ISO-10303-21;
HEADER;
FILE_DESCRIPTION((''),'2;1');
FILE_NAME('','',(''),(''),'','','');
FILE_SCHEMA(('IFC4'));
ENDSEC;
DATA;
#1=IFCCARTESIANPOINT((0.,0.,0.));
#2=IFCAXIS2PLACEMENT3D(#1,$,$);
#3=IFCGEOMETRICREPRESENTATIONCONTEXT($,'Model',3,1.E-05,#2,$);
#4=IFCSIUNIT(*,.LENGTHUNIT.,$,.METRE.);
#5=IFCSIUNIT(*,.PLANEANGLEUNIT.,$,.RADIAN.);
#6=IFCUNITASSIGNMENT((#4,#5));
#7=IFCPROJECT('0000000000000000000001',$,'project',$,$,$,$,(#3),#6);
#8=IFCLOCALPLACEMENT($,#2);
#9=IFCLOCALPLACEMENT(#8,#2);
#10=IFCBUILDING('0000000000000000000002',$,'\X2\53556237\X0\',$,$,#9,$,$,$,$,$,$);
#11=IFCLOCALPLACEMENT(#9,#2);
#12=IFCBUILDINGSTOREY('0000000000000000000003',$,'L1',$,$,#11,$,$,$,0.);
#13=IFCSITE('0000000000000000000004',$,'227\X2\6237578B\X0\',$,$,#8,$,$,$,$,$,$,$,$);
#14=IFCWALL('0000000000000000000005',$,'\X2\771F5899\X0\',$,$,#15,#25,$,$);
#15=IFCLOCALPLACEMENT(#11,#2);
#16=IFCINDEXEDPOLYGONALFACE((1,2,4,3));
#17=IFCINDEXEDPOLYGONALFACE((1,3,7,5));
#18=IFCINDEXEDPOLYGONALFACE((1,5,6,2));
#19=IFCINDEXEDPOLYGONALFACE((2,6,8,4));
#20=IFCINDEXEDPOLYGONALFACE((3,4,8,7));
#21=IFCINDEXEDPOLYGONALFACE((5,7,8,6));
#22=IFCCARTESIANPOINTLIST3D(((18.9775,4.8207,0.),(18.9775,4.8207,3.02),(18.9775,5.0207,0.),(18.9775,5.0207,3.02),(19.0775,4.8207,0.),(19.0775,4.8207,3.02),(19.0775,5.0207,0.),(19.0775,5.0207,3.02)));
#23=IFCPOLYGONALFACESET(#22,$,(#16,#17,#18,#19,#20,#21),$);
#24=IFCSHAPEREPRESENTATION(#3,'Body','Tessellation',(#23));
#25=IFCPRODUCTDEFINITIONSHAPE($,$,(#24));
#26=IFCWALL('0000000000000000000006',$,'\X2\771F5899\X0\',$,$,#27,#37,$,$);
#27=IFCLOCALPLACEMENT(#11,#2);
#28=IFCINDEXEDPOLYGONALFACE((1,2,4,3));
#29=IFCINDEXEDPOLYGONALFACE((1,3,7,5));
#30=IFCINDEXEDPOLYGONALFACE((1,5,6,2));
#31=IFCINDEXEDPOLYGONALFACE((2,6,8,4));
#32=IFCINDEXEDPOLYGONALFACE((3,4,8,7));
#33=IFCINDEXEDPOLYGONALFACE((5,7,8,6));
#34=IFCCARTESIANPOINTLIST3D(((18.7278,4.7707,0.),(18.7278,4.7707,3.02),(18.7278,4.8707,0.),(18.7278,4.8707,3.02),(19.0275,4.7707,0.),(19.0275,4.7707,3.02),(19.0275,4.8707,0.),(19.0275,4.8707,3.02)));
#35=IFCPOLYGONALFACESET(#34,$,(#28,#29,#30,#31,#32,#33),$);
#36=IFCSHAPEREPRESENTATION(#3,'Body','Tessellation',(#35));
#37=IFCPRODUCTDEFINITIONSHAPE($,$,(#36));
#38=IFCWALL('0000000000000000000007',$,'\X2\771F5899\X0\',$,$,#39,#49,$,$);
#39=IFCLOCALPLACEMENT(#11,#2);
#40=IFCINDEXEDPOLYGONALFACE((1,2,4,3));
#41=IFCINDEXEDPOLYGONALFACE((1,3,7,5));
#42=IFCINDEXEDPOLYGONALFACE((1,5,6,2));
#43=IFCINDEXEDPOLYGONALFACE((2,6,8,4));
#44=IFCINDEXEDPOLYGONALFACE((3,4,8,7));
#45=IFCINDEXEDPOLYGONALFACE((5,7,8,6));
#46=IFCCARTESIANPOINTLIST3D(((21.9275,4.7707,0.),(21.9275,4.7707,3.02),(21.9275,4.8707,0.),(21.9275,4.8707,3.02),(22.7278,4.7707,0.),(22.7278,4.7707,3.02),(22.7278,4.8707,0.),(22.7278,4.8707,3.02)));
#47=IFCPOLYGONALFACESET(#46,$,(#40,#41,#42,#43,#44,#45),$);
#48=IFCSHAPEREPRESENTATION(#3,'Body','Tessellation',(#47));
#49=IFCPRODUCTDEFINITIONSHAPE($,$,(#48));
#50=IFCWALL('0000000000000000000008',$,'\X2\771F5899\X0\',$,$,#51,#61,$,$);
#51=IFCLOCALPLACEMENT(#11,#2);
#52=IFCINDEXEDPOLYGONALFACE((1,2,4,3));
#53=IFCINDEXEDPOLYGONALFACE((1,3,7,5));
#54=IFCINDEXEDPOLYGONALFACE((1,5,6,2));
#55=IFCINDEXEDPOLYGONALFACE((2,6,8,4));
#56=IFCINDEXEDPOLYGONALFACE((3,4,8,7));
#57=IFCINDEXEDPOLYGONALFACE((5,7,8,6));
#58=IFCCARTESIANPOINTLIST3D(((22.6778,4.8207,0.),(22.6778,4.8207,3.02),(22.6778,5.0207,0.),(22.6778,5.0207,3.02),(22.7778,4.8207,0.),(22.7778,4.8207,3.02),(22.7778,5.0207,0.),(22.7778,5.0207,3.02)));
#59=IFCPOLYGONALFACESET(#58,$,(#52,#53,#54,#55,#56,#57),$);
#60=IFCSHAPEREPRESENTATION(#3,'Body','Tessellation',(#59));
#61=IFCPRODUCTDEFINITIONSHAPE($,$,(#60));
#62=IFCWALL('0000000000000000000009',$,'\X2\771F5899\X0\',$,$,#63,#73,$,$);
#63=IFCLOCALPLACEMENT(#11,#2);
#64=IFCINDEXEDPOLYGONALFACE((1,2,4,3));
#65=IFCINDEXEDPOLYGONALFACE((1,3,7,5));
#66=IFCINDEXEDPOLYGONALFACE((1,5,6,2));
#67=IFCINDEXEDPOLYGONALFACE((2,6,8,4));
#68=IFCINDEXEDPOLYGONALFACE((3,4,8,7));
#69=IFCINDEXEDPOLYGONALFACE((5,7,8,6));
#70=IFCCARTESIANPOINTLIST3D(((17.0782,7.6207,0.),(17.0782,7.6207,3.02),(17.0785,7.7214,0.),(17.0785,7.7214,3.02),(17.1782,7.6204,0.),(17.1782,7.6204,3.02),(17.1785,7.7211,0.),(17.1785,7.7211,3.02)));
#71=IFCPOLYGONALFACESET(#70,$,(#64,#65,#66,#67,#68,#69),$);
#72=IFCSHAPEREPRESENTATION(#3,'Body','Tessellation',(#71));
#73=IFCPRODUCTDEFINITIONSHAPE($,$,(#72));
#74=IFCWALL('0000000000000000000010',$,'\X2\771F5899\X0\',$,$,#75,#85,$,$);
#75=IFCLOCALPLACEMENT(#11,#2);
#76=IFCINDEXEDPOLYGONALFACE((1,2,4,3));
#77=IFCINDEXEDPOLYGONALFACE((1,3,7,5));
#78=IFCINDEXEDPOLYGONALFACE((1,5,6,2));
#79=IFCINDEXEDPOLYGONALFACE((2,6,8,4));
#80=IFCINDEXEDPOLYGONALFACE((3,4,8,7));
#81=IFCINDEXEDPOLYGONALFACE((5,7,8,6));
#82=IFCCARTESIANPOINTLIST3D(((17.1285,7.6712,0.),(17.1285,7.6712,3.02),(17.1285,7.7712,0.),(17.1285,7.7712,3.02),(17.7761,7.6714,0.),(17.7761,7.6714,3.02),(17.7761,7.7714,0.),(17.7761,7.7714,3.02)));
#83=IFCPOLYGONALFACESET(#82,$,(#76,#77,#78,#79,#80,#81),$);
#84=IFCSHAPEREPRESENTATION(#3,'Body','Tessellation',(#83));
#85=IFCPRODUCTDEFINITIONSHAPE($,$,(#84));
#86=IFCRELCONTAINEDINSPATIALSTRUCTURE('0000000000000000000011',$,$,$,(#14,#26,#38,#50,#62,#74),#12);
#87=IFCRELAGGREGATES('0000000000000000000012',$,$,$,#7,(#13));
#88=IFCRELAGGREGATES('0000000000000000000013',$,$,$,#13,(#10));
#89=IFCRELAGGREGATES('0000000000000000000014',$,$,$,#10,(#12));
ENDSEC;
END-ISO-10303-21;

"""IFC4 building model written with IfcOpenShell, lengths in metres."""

from ifc_helpers import new_model, si_unit, origin, place, context, project, spatial, polyline, outline, extrude, element, save


model = new_model("IFC4")

# Units and contexts
model_context = context("Model", 3, precision=1e-05, world=origin())
ifc_project = project(units=[si_unit("LENGTHUNIT", "METRE"), si_unit("PLANEANGLEUNIT", "RADIAN")], contexts=[model_context])

# Site, building, storey
site_placement = place(None, origin())
site = spatial("IfcSite", under=ifc_project, at=site_placement, Name="227户型")
building_placement = place(site_placement, origin())
building = spatial("IfcBuilding", under=site, at=building_placement, Name="单户")
storey_placement = place(building_placement, origin())
storey = spatial("IfcBuildingStorey", under=building, at=storey_placement, Name="L1", Elevation=0.0)

# Walls
wall_1_placement = place(storey_placement, origin())
element("IfcWall", 1, at=wall_1_placement, inside=storey, Name="真墙", context=model_context, shape_type="SweptSolid", body=[
    extrude(outline(polyline([(19.0775, 5.0207), (19.0775, 4.8207), (18.9775, 4.8207), (18.9775, 5.0207), (19.0775, 5.0207)])), origin(), (0.0, 0.0, 1.0), 3.02),
])
wall_2_placement = place(storey_placement, origin())
element("IfcWall", 2, at=wall_2_placement, inside=storey, Name="真墙", context=model_context, shape_type="SweptSolid", body=[
    extrude(outline(polyline([(19.0275, 4.7707), (18.7278, 4.7707), (18.7278, 4.8707), (19.0275, 4.8707), (19.0275, 4.7707)])), origin(), (0.0, 0.0, 1.0), 3.02),
])
wall_3_placement = place(storey_placement, origin())
element("IfcWall", 3, at=wall_3_placement, inside=storey, Name="真墙", context=model_context, shape_type="SweptSolid", body=[
    extrude(outline(polyline([(21.9275, 4.8707), (22.7278, 4.8707), (22.7278, 4.7707), (21.9275, 4.7707), (21.9275, 4.8707)])), origin(), (0.0, 0.0, 1.0), 3.02),
])
wall_4_placement = place(storey_placement, origin())
element("IfcWall", 4, at=wall_4_placement, inside=storey, Name="真墙", context=model_context, shape_type="SweptSolid", body=[
    extrude(outline(polyline([(22.6778, 4.8207), (22.6778, 5.0207), (22.7778, 5.0207), (22.7778, 4.8207), (22.6778, 4.8207)])), origin(), (0.0, 0.0, 1.0), 3.02),
])

# Walls
wall_5_placement = place(storey_placement, origin())
element("IfcWall", 5, at=wall_5_placement, inside=storey, Name="真墙", context=model_context, shape_type="SweptSolid", body=[
    extrude(outline(polyline([(17.0782, 7.6207), (17.0785, 7.7214), (17.1785, 7.7211), (17.1782, 7.6204), (17.0782, 7.6207)])), origin(), (0.0, 0.0, 1.0), 3.02),
])
wall_6_placement = place(storey_placement, origin())
element("IfcWall", 6, at=wall_6_placement, inside=storey, Name="真墙", context=model_context, shape_type="SweptSolid", body=[
    extrude(outline(polyline([(17.1285, 7.7712), (17.7761, 7.7714), (17.7761, 7.6714), (17.1285, 7.6712), (17.1285, 7.7712)])), origin(), (0.0, 0.0, 1.0), 3.02),
])

save(model, "model.ifc")
